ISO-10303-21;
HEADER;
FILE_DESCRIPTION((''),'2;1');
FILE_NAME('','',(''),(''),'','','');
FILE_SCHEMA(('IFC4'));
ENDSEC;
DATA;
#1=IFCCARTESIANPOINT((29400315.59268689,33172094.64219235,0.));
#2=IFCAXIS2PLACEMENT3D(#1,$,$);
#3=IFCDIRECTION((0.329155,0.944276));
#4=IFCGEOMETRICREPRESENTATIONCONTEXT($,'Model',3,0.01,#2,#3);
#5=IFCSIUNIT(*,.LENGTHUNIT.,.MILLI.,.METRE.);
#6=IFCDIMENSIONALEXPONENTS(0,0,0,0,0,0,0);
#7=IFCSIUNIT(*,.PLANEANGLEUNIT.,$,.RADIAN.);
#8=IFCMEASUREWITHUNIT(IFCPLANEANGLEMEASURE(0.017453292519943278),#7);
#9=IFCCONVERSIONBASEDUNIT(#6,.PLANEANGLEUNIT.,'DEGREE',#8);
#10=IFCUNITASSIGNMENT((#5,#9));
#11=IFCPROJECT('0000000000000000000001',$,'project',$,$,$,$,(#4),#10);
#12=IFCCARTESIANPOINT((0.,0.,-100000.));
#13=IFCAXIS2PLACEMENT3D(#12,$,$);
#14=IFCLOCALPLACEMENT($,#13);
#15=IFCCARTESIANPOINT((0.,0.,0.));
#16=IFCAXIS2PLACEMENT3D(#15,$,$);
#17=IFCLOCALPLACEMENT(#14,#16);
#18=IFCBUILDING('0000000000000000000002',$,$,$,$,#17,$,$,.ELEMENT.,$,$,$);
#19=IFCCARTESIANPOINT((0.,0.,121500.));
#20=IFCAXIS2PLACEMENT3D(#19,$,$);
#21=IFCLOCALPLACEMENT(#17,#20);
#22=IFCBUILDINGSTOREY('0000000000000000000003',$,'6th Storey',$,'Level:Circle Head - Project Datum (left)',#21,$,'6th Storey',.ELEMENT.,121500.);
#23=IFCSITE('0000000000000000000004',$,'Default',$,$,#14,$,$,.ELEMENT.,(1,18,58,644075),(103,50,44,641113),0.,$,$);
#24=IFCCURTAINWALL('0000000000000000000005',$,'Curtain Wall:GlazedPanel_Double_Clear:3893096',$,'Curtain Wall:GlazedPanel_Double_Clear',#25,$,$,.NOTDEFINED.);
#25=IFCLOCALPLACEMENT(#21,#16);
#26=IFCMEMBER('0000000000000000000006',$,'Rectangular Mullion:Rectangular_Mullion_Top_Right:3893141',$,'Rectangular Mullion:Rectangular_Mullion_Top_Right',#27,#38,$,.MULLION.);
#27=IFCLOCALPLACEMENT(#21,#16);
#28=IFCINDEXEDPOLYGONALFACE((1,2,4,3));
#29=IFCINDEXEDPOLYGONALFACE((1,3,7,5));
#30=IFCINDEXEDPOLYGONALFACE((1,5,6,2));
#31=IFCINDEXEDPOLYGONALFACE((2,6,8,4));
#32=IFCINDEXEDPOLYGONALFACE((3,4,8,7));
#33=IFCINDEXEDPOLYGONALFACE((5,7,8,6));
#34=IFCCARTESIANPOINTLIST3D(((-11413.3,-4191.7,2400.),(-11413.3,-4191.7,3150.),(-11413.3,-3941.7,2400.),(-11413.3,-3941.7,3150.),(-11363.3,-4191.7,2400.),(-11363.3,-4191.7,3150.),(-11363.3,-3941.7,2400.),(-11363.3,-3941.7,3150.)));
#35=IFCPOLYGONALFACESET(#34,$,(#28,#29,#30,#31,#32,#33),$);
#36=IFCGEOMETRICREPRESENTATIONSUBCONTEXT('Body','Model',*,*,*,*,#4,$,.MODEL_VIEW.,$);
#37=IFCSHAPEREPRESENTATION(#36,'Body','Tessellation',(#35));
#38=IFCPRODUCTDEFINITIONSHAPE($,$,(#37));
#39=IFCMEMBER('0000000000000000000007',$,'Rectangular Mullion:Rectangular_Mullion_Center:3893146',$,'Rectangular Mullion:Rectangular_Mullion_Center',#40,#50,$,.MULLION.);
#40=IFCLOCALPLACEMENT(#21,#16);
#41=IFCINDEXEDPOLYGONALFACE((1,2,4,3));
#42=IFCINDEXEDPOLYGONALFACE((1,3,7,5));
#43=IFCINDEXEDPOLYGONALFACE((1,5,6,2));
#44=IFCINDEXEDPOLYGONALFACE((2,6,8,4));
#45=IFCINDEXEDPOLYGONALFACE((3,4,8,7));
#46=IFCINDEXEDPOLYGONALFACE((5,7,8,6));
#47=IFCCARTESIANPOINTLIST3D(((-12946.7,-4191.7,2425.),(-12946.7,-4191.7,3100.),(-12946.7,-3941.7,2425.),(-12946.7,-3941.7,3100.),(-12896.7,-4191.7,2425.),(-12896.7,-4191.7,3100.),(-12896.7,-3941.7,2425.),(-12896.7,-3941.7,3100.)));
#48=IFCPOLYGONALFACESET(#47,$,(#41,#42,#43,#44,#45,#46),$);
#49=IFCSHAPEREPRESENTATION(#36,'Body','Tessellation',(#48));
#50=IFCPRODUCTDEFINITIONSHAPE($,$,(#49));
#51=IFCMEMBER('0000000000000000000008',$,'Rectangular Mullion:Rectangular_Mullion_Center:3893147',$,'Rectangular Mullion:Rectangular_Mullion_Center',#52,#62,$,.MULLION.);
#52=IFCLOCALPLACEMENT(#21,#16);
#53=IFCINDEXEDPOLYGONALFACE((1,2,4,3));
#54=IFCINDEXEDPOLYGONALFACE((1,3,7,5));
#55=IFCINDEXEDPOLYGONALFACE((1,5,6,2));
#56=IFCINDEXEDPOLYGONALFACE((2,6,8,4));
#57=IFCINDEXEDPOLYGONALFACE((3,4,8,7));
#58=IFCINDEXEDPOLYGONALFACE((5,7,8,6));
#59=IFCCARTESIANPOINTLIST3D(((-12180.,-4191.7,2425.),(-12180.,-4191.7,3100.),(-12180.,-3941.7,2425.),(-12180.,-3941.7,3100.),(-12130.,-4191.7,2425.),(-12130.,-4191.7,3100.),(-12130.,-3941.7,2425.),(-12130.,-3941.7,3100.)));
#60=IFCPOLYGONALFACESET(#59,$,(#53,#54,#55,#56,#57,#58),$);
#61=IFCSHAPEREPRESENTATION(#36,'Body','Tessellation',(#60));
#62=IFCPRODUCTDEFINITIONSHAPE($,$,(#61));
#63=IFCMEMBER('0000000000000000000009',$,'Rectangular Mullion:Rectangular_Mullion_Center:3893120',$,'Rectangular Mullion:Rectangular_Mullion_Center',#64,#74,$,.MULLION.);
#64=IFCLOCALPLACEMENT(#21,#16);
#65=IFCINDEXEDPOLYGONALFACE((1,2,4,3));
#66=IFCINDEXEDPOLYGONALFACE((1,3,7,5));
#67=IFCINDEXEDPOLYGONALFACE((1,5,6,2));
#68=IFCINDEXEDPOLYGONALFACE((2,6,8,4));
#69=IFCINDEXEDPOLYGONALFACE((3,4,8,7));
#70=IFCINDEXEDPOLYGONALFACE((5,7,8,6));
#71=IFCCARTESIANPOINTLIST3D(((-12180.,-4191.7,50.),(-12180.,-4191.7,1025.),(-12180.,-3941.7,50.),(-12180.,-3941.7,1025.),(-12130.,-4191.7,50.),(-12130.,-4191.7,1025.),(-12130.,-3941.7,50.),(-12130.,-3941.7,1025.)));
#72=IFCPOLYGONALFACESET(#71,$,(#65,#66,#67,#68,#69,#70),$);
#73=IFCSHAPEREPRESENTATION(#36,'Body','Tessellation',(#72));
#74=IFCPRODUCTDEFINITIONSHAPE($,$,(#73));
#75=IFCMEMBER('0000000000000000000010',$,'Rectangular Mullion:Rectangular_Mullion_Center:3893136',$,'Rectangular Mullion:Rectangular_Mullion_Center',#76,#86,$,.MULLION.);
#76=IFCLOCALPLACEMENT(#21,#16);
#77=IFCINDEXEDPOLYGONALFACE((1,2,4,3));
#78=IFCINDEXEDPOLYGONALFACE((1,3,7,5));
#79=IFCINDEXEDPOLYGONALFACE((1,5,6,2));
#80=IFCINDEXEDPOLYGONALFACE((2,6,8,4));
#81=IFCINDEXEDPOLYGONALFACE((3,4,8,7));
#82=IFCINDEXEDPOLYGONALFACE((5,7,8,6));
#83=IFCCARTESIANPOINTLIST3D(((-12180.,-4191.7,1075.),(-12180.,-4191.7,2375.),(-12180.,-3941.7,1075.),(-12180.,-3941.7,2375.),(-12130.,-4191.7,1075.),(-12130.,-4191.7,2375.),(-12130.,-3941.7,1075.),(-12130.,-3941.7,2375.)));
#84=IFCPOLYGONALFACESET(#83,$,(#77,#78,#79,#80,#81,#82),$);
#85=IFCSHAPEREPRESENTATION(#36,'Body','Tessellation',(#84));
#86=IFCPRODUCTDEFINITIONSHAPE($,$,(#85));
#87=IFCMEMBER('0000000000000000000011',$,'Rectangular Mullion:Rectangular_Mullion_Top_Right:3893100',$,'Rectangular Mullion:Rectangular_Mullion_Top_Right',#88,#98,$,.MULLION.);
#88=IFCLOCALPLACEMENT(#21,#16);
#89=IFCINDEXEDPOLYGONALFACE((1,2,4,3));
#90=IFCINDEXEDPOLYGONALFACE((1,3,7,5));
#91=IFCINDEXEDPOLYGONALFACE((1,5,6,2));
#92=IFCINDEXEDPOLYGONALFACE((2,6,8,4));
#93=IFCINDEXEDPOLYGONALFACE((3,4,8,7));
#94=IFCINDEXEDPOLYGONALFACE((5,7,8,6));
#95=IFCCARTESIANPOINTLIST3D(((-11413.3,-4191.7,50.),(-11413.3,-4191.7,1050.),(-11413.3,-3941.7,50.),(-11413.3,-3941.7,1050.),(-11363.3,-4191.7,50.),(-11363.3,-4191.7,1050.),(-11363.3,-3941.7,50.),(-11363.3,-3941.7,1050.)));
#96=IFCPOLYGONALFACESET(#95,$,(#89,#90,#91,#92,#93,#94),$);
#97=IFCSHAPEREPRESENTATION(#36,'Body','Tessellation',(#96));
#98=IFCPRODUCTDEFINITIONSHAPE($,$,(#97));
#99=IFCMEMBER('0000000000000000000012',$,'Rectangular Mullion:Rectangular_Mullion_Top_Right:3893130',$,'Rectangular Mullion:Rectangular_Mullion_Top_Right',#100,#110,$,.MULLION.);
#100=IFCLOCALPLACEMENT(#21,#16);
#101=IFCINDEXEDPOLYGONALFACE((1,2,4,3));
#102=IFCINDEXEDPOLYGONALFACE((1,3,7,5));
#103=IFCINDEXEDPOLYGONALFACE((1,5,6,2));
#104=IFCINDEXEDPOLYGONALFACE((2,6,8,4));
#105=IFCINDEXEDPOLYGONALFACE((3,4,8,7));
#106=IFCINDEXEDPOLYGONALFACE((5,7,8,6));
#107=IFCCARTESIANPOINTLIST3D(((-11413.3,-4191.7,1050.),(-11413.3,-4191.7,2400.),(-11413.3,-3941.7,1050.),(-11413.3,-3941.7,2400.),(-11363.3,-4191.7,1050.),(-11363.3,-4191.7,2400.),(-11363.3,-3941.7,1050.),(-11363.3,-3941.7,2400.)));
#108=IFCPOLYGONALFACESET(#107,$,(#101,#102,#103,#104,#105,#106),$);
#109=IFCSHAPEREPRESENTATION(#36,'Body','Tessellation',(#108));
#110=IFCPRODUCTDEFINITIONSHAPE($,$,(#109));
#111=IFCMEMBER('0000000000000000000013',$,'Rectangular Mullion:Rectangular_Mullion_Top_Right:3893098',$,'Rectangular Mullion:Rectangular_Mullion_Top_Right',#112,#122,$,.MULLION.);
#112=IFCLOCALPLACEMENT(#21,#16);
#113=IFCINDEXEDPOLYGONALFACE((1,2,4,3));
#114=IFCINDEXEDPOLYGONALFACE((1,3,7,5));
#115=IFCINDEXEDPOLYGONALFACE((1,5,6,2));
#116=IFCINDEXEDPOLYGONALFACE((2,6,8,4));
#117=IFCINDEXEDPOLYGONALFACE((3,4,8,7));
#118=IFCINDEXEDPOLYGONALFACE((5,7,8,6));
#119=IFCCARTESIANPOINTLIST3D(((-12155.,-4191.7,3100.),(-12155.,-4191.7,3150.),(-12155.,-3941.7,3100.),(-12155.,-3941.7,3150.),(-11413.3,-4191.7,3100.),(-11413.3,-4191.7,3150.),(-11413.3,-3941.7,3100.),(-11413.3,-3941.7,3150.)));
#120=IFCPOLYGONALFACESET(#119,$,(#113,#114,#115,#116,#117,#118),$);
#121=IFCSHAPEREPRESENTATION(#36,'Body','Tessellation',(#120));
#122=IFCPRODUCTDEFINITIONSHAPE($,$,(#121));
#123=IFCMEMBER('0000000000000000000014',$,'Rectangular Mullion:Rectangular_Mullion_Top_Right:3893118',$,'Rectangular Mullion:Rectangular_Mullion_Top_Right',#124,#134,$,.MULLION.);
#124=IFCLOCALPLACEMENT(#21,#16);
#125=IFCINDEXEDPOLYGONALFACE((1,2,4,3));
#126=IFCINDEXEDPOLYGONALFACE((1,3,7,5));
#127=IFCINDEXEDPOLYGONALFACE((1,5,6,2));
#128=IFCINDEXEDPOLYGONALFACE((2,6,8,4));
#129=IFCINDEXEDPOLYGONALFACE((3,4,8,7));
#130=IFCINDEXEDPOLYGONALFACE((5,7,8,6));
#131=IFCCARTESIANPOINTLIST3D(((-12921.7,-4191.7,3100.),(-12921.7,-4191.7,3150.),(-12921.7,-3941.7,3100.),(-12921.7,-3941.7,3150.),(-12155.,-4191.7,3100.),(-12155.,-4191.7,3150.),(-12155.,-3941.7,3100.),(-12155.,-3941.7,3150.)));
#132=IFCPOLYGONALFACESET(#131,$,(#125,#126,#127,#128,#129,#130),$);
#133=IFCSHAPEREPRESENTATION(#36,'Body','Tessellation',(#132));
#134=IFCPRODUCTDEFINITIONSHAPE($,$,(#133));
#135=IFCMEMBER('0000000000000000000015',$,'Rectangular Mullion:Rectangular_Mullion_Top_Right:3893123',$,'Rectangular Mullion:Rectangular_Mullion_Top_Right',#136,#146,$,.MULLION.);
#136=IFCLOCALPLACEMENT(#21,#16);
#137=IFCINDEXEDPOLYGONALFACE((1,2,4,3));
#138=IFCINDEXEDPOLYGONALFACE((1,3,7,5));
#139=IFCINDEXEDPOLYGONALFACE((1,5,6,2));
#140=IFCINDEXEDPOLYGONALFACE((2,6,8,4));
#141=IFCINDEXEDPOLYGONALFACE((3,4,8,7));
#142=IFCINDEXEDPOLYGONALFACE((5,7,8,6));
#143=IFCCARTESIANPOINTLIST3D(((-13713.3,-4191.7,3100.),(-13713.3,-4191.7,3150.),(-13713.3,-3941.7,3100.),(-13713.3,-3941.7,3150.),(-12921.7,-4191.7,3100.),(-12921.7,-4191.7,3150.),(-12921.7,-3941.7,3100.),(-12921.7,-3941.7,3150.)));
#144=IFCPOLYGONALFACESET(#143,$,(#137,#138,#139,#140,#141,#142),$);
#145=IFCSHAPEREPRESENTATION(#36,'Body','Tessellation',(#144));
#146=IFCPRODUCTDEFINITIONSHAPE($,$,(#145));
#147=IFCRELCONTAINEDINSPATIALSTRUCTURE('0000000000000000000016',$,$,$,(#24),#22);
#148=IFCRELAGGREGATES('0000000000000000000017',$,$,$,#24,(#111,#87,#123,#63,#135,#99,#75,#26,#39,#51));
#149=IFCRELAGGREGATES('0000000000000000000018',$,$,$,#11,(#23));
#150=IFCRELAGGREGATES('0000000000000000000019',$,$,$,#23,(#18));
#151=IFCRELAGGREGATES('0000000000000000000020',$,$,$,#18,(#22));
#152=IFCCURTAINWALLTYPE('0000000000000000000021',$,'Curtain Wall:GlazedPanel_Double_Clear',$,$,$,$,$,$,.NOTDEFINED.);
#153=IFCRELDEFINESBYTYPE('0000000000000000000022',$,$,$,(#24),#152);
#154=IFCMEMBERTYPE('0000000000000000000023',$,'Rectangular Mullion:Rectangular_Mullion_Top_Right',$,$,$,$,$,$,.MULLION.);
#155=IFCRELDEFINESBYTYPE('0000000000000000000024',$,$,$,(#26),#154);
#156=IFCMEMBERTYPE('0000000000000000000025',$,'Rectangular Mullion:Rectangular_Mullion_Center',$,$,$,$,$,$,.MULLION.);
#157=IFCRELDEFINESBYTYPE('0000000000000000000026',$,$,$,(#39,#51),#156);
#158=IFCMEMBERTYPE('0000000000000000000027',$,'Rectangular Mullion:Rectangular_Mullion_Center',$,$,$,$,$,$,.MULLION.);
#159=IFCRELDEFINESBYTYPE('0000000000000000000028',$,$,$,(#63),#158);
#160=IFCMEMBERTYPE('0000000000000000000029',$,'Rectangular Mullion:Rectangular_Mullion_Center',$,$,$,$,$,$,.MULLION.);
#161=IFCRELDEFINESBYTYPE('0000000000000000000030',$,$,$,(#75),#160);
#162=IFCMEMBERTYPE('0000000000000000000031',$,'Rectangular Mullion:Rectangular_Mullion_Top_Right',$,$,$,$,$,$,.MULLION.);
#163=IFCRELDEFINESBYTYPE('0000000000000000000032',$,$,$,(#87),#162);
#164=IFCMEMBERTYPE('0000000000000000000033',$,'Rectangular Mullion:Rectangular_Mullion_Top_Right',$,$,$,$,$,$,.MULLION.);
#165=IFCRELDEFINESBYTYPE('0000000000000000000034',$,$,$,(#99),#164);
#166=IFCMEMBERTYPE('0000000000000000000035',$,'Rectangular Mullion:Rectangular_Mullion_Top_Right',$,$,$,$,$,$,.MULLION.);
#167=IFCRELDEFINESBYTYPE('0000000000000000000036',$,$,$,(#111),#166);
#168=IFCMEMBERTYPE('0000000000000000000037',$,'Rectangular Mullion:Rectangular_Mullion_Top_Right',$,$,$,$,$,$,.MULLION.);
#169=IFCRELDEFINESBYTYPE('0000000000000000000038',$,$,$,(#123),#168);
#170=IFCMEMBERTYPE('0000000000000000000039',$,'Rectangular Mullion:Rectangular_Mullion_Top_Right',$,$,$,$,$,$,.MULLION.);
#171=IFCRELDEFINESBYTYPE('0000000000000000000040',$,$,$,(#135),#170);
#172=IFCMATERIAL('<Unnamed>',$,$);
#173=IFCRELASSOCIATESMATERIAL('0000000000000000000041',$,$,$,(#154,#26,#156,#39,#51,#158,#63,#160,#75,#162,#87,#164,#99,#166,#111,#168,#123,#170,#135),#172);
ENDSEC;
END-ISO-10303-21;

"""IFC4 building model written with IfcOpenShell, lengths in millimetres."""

from ifc_helpers import new_model, entity, si_unit, converted_unit, direction, frame, origin, place, context, subcontext, project, spatial, indexed_curve, outline, extrude, source, transform, mapped, material, type_object, type_shapes, element, aggregate, save


model = new_model("IFC4")

# Units and contexts
model_context = context("Model", 3, precision=0.01, world=frame((29400315.59268689, 33172094.64219235, 0.0)), true_north=direction((0.329155, 0.944276)))
body_context = subcontext(model_context, "Body", "Model", "MODEL_VIEW")
ifc_project = project(units=[si_unit("LENGTHUNIT", "METRE", prefix="MILLI"), converted_unit("PLANEANGLEUNIT", "DEGREE", entity("IfcPlaneAngleMeasure", 0.017453292519943278), si_unit("PLANEANGLEUNIT", "RADIAN"), dimensions=[0, 0, 0, 0, 0, 0, 0])], contexts=[model_context])

# Site, building, storey
site_placement = place(None, frame((0.0, 0.0, -100000.0)))
site = spatial("IfcSite", under=ifc_project, at=site_placement, Name="Default", CompositionType="ELEMENT", RefLatitude=(1, 18, 58, 644075), RefLongitude=(103, 50, 44, 641113), RefElevation=0.0)
building_placement = place(site_placement, origin())
building = spatial("IfcBuilding", under=site, at=building_placement, CompositionType="ELEMENT")
storey_placement = place(building_placement, frame((0.0, 0.0, 121500.0)))
storey = spatial("IfcBuildingStorey", under=building, at=storey_placement, Name="6th Storey", ObjectType="Level:Circle Head - Project Datum (left)", LongName="6th Storey", CompositionType="ELEMENT", Elevation=121500.0)

# Curtain wall, members
curtain_wall_type = type_object("IfcCurtainWallType", Name="Curtain Wall:GlazedPanel_Double_Clear", PredefinedType="NOTDEFINED")
curtain_wall_1_placement = place(storey_placement, frame((0.0, 0.0, -121500.0)))
curtain_wall_1 = element("IfcCurtainWall", 1, at=curtain_wall_1_placement, inside=storey, type_object=curtain_wall_type, Name="Curtain Wall:GlazedPanel_Double_Clear:3893096", ObjectType="Curtain Wall:GlazedPanel_Double_Clear", PredefinedType="NOTDEFINED")
ifc_material_1 = material(Name="<Unnamed>")
member_type_1 = type_object("IfcMemberType", Name="Rectangular Mullion:Rectangular_Mullion_Top_Right", PredefinedType="MULLION", material=ifc_material_1)
shared_shape_1 = source(origin(), body_context, "Body", "SweptSolid", [
    extrude(outline(indexed_curve([(-25.0, -125.0), (25.0, -125.0), (25.0, 125.0), (-25.0, 125.0), (-25.0, -125.0)], self_intersect=False)), frame((-25.0, 0.0, -750.0), z_axis=(0.0, 0.0, 1.0), x_axis=(-1.0, 0.0, 0.0)), (0.0, 0.0, 1.0), 750.0),
])
type_shapes(member_type_1, [shared_shape_1])
member_1_placement = place(curtain_wall_1_placement, frame((-11363.3, -4066.7, 123900.0), z_axis=(0.0, 0.0, -1.0), x_axis=(1.0, 0.0, 0.0)))
member_1 = element("IfcMember", 2, at=member_1_placement, type_object=member_type_1, material=ifc_material_1, Name="Rectangular Mullion:Rectangular_Mullion_Top_Right:3893141", ObjectType="Rectangular Mullion:Rectangular_Mullion_Top_Right", PredefinedType="MULLION", context=body_context, shape_type="MappedRepresentation", body=[
    mapped(shared_shape_1, transform((0.0, 0.0, 0.0), scale=1.0)),
])
member_type_2 = type_object("IfcMemberType", Name="Rectangular Mullion:Rectangular_Mullion_Center", PredefinedType="MULLION", material=ifc_material_1)
shared_shape_2 = source(origin(), body_context, "Body", "SweptSolid", [
    extrude(outline(indexed_curve([(-25.0, -125.0), (25.0, -125.0), (25.0, 125.0), (-25.0, 125.0), (-25.0, -125.0)], self_intersect=False)), frame((0.0, 0.0, -675.0), z_axis=(0.0, 0.0, 1.0), x_axis=(-1.0, 0.0, 0.0)), (0.0, 0.0, 1.0), 675.0),
])
type_shapes(member_type_2, [shared_shape_2])
member_2_placement = place(curtain_wall_1_placement, frame((-12921.7, -4066.7, 123925.0), z_axis=(0.0, 0.0, -1.0), x_axis=(1.0, 0.0, 0.0)))
member_2 = element("IfcMember", 3, at=member_2_placement, type_object=member_type_2, material=ifc_material_1, Name="Rectangular Mullion:Rectangular_Mullion_Center:3893146", ObjectType="Rectangular Mullion:Rectangular_Mullion_Center", PredefinedType="MULLION", context=body_context, shape_type="MappedRepresentation", body=[
    mapped(shared_shape_2, transform((0.0, 0.0, 0.0), scale=1.0)),
])
member_3_placement = place(curtain_wall_1_placement, frame((-12155.0, -4066.7, 123925.0), z_axis=(0.0, 0.0, -1.0), x_axis=(1.0, 0.0, 0.0)))
member_3 = element("IfcMember", 4, at=member_3_placement, type_object=member_type_2, material=ifc_material_1, Name="Rectangular Mullion:Rectangular_Mullion_Center:3893147", ObjectType="Rectangular Mullion:Rectangular_Mullion_Center", PredefinedType="MULLION", context=body_context, shape_type="MappedRepresentation", body=[
    mapped(shared_shape_2, transform((0.0, 0.0, 0.0), scale=1.0)),
])
member_type_3 = type_object("IfcMemberType", Name="Rectangular Mullion:Rectangular_Mullion_Center", PredefinedType="MULLION", material=ifc_material_1)
shared_shape_3 = source(origin(), body_context, "Body", "SweptSolid", [
    extrude(outline(indexed_curve([(-25.0, -125.0), (25.0, -125.0), (25.0, 125.0), (-25.0, 125.0), (-25.0, -125.0)], self_intersect=False)), frame((0.0, 0.0, -975.0), z_axis=(0.0, 0.0, 1.0), x_axis=(-1.0, 0.0, 0.0)), (0.0, 0.0, 1.0), 975.0),
])
type_shapes(member_type_3, [shared_shape_3])
member_4_placement = place(curtain_wall_1_placement, frame((-12155.0, -4066.7, 121550.0), z_axis=(0.0, 0.0, -1.0), x_axis=(1.0, 0.0, 0.0)))
member_4 = element("IfcMember", 5, at=member_4_placement, type_object=member_type_3, material=ifc_material_1, Name="Rectangular Mullion:Rectangular_Mullion_Center:3893120", ObjectType="Rectangular Mullion:Rectangular_Mullion_Center", PredefinedType="MULLION", context=body_context, shape_type="MappedRepresentation", body=[
    mapped(shared_shape_3, transform((0.0, 0.0, 0.0), scale=1.0)),
])
member_type_4 = type_object("IfcMemberType", Name="Rectangular Mullion:Rectangular_Mullion_Center", PredefinedType="MULLION", material=ifc_material_1)
shared_shape_4 = source(origin(), body_context, "Body", "SweptSolid", [
    extrude(outline(indexed_curve([(-25.0, -125.0), (25.0, -125.0), (25.0, 125.0), (-25.0, 125.0), (-25.0, -125.0)], self_intersect=False)), frame((0.0, 0.0, -1300.0), z_axis=(0.0, 0.0, 1.0), x_axis=(-1.0, 0.0, 0.0)), (0.0, 0.0, 1.0), 1300.0),
])
type_shapes(member_type_4, [shared_shape_4])
member_5_placement = place(curtain_wall_1_placement, frame((-12155.0, -4066.7, 122575.0), z_axis=(0.0, 0.0, -1.0), x_axis=(1.0, 0.0, 0.0)))
member_5 = element("IfcMember", 6, at=member_5_placement, type_object=member_type_4, material=ifc_material_1, Name="Rectangular Mullion:Rectangular_Mullion_Center:3893136", ObjectType="Rectangular Mullion:Rectangular_Mullion_Center", PredefinedType="MULLION", context=body_context, shape_type="MappedRepresentation", body=[
    mapped(shared_shape_4, transform((0.0, 0.0, 0.0), scale=1.0)),
])
member_type_5 = type_object("IfcMemberType", Name="Rectangular Mullion:Rectangular_Mullion_Top_Right", PredefinedType="MULLION", material=ifc_material_1)
shared_shape_5 = source(origin(), body_context, "Body", "SweptSolid", [
    extrude(outline(indexed_curve([(-25.0, -125.0), (25.0, -125.0), (25.0, 125.0), (-25.0, 125.0), (-25.0, -125.0)], self_intersect=False)), frame((-25.0, 0.0, -1000.0), z_axis=(0.0, 0.0, 1.0), x_axis=(-1.0, 0.0, 0.0)), (0.0, 0.0, 1.0), 1000.0),
])
type_shapes(member_type_5, [shared_shape_5])
member_6_placement = place(curtain_wall_1_placement, frame((-11363.3, -4066.7, 121550.0), z_axis=(0.0, 0.0, -1.0), x_axis=(1.0, 0.0, 0.0)))
member_6 = element("IfcMember", 7, at=member_6_placement, type_object=member_type_5, material=ifc_material_1, Name="Rectangular Mullion:Rectangular_Mullion_Top_Right:3893100", ObjectType="Rectangular Mullion:Rectangular_Mullion_Top_Right", PredefinedType="MULLION", context=body_context, shape_type="MappedRepresentation", body=[
    mapped(shared_shape_5, transform((0.0, 0.0, 0.0), scale=1.0)),
])
member_type_6 = type_object("IfcMemberType", Name="Rectangular Mullion:Rectangular_Mullion_Top_Right", PredefinedType="MULLION", material=ifc_material_1)
shared_shape_6 = source(origin(), body_context, "Body", "SweptSolid", [
    extrude(outline(indexed_curve([(-25.0, -125.0), (25.0, -125.0), (25.0, 125.0), (-25.0, 125.0), (-25.0, -125.0)], self_intersect=False)), frame((-25.0, 0.0, -1350.0), z_axis=(0.0, 0.0, 1.0), x_axis=(-1.0, 0.0, 0.0)), (0.0, 0.0, 1.0), 1350.0),
])
type_shapes(member_type_6, [shared_shape_6])
member_7_placement = place(curtain_wall_1_placement, frame((-11363.3, -4066.7, 122550.0), z_axis=(0.0, 0.0, -1.0), x_axis=(1.0, 0.0, 0.0)))
member_7 = element("IfcMember", 8, at=member_7_placement, type_object=member_type_6, material=ifc_material_1, Name="Rectangular Mullion:Rectangular_Mullion_Top_Right:3893130", ObjectType="Rectangular Mullion:Rectangular_Mullion_Top_Right", PredefinedType="MULLION", context=body_context, shape_type="MappedRepresentation", body=[
    mapped(shared_shape_6, transform((0.0, 0.0, 0.0), scale=1.0)),
])
member_type_7 = type_object("IfcMemberType", Name="Rectangular Mullion:Rectangular_Mullion_Top_Right", PredefinedType="MULLION", material=ifc_material_1)
shared_shape_7 = source(origin(), body_context, "Body", "SweptSolid", [
    extrude(outline(indexed_curve([(-25.0, -125.0), (25.0, -125.0), (25.0, 125.0), (-25.0, 125.0), (-25.0, -125.0)], self_intersect=False)), frame((-25.0, 0.0, -741.7), z_axis=(0.0, 0.0, 1.0), x_axis=(-1.0, 0.0, 0.0)), (0.0, 0.0, 1.0), 741.7),
])
type_shapes(member_type_7, [shared_shape_7])
member_8_placement = place(curtain_wall_1_placement, frame((-11413.3, -4066.7, 124650.0), z_axis=(1.0, 0.0, 0.0), x_axis=(0.0, 0.0, 1.0)))
member_8 = element("IfcMember", 9, at=member_8_placement, type_object=member_type_7, material=ifc_material_1, Name="Rectangular Mullion:Rectangular_Mullion_Top_Right:3893098", ObjectType="Rectangular Mullion:Rectangular_Mullion_Top_Right", PredefinedType="MULLION", context=body_context, shape_type="MappedRepresentation", body=[
    mapped(shared_shape_7, transform((0.0, 0.0, 0.0), scale=1.0)),
])
member_type_8 = type_object("IfcMemberType", Name="Rectangular Mullion:Rectangular_Mullion_Top_Right", PredefinedType="MULLION", material=ifc_material_1)
shared_shape_8 = source(origin(), body_context, "Body", "SweptSolid", [
    extrude(outline(indexed_curve([(-25.0, -125.0), (25.0, -125.0), (25.0, 125.0), (-25.0, 125.0), (-25.0, -125.0)], self_intersect=False)), frame((-25.0, 0.0, -766.7), z_axis=(0.0, 0.0, 1.0), x_axis=(-1.0, 0.0, 0.0)), (0.0, 0.0, 1.0), 766.7),
])
type_shapes(member_type_8, [shared_shape_8])
member_9_placement = place(curtain_wall_1_placement, frame((-12155.0, -4066.7, 124650.0), z_axis=(1.0, 0.0, 0.0), x_axis=(0.0, 0.0, 1.0)))
member_9 = element("IfcMember", 10, at=member_9_placement, type_object=member_type_8, material=ifc_material_1, Name="Rectangular Mullion:Rectangular_Mullion_Top_Right:3893118", ObjectType="Rectangular Mullion:Rectangular_Mullion_Top_Right", PredefinedType="MULLION", context=body_context, shape_type="MappedRepresentation", body=[
    mapped(shared_shape_8, transform((0.0, 0.0, 0.0), scale=1.0)),
])
member_type_9 = type_object("IfcMemberType", Name="Rectangular Mullion:Rectangular_Mullion_Top_Right", PredefinedType="MULLION", material=ifc_material_1)
shared_shape_9 = source(origin(), body_context, "Body", "SweptSolid", [
    extrude(outline(indexed_curve([(-25.0, -125.0), (25.0, -125.0), (25.0, 125.0), (-25.0, 125.0), (-25.0, -125.0)], self_intersect=False)), frame((-25.0, 0.0, -791.7), z_axis=(0.0, 0.0, 1.0), x_axis=(-1.0, 0.0, 0.0)), (0.0, 0.0, 1.0), 791.7),
])
type_shapes(member_type_9, [shared_shape_9])
member_10_placement = place(curtain_wall_1_placement, frame((-12921.7, -4066.7, 124650.0), z_axis=(1.0, 0.0, 0.0), x_axis=(0.0, 0.0, 1.0)))
member_10 = element("IfcMember", 11, at=member_10_placement, type_object=member_type_9, material=ifc_material_1, Name="Rectangular Mullion:Rectangular_Mullion_Top_Right:3893123", ObjectType="Rectangular Mullion:Rectangular_Mullion_Top_Right", PredefinedType="MULLION", context=body_context, shape_type="MappedRepresentation", body=[
    mapped(shared_shape_9, transform((0.0, 0.0, 0.0), scale=1.0)),
])
aggregate(curtain_wall_1, [member_8, member_6, member_9, member_4, member_10, member_7, member_5, member_1, member_2, member_3])

save(model, "model.ifc")
